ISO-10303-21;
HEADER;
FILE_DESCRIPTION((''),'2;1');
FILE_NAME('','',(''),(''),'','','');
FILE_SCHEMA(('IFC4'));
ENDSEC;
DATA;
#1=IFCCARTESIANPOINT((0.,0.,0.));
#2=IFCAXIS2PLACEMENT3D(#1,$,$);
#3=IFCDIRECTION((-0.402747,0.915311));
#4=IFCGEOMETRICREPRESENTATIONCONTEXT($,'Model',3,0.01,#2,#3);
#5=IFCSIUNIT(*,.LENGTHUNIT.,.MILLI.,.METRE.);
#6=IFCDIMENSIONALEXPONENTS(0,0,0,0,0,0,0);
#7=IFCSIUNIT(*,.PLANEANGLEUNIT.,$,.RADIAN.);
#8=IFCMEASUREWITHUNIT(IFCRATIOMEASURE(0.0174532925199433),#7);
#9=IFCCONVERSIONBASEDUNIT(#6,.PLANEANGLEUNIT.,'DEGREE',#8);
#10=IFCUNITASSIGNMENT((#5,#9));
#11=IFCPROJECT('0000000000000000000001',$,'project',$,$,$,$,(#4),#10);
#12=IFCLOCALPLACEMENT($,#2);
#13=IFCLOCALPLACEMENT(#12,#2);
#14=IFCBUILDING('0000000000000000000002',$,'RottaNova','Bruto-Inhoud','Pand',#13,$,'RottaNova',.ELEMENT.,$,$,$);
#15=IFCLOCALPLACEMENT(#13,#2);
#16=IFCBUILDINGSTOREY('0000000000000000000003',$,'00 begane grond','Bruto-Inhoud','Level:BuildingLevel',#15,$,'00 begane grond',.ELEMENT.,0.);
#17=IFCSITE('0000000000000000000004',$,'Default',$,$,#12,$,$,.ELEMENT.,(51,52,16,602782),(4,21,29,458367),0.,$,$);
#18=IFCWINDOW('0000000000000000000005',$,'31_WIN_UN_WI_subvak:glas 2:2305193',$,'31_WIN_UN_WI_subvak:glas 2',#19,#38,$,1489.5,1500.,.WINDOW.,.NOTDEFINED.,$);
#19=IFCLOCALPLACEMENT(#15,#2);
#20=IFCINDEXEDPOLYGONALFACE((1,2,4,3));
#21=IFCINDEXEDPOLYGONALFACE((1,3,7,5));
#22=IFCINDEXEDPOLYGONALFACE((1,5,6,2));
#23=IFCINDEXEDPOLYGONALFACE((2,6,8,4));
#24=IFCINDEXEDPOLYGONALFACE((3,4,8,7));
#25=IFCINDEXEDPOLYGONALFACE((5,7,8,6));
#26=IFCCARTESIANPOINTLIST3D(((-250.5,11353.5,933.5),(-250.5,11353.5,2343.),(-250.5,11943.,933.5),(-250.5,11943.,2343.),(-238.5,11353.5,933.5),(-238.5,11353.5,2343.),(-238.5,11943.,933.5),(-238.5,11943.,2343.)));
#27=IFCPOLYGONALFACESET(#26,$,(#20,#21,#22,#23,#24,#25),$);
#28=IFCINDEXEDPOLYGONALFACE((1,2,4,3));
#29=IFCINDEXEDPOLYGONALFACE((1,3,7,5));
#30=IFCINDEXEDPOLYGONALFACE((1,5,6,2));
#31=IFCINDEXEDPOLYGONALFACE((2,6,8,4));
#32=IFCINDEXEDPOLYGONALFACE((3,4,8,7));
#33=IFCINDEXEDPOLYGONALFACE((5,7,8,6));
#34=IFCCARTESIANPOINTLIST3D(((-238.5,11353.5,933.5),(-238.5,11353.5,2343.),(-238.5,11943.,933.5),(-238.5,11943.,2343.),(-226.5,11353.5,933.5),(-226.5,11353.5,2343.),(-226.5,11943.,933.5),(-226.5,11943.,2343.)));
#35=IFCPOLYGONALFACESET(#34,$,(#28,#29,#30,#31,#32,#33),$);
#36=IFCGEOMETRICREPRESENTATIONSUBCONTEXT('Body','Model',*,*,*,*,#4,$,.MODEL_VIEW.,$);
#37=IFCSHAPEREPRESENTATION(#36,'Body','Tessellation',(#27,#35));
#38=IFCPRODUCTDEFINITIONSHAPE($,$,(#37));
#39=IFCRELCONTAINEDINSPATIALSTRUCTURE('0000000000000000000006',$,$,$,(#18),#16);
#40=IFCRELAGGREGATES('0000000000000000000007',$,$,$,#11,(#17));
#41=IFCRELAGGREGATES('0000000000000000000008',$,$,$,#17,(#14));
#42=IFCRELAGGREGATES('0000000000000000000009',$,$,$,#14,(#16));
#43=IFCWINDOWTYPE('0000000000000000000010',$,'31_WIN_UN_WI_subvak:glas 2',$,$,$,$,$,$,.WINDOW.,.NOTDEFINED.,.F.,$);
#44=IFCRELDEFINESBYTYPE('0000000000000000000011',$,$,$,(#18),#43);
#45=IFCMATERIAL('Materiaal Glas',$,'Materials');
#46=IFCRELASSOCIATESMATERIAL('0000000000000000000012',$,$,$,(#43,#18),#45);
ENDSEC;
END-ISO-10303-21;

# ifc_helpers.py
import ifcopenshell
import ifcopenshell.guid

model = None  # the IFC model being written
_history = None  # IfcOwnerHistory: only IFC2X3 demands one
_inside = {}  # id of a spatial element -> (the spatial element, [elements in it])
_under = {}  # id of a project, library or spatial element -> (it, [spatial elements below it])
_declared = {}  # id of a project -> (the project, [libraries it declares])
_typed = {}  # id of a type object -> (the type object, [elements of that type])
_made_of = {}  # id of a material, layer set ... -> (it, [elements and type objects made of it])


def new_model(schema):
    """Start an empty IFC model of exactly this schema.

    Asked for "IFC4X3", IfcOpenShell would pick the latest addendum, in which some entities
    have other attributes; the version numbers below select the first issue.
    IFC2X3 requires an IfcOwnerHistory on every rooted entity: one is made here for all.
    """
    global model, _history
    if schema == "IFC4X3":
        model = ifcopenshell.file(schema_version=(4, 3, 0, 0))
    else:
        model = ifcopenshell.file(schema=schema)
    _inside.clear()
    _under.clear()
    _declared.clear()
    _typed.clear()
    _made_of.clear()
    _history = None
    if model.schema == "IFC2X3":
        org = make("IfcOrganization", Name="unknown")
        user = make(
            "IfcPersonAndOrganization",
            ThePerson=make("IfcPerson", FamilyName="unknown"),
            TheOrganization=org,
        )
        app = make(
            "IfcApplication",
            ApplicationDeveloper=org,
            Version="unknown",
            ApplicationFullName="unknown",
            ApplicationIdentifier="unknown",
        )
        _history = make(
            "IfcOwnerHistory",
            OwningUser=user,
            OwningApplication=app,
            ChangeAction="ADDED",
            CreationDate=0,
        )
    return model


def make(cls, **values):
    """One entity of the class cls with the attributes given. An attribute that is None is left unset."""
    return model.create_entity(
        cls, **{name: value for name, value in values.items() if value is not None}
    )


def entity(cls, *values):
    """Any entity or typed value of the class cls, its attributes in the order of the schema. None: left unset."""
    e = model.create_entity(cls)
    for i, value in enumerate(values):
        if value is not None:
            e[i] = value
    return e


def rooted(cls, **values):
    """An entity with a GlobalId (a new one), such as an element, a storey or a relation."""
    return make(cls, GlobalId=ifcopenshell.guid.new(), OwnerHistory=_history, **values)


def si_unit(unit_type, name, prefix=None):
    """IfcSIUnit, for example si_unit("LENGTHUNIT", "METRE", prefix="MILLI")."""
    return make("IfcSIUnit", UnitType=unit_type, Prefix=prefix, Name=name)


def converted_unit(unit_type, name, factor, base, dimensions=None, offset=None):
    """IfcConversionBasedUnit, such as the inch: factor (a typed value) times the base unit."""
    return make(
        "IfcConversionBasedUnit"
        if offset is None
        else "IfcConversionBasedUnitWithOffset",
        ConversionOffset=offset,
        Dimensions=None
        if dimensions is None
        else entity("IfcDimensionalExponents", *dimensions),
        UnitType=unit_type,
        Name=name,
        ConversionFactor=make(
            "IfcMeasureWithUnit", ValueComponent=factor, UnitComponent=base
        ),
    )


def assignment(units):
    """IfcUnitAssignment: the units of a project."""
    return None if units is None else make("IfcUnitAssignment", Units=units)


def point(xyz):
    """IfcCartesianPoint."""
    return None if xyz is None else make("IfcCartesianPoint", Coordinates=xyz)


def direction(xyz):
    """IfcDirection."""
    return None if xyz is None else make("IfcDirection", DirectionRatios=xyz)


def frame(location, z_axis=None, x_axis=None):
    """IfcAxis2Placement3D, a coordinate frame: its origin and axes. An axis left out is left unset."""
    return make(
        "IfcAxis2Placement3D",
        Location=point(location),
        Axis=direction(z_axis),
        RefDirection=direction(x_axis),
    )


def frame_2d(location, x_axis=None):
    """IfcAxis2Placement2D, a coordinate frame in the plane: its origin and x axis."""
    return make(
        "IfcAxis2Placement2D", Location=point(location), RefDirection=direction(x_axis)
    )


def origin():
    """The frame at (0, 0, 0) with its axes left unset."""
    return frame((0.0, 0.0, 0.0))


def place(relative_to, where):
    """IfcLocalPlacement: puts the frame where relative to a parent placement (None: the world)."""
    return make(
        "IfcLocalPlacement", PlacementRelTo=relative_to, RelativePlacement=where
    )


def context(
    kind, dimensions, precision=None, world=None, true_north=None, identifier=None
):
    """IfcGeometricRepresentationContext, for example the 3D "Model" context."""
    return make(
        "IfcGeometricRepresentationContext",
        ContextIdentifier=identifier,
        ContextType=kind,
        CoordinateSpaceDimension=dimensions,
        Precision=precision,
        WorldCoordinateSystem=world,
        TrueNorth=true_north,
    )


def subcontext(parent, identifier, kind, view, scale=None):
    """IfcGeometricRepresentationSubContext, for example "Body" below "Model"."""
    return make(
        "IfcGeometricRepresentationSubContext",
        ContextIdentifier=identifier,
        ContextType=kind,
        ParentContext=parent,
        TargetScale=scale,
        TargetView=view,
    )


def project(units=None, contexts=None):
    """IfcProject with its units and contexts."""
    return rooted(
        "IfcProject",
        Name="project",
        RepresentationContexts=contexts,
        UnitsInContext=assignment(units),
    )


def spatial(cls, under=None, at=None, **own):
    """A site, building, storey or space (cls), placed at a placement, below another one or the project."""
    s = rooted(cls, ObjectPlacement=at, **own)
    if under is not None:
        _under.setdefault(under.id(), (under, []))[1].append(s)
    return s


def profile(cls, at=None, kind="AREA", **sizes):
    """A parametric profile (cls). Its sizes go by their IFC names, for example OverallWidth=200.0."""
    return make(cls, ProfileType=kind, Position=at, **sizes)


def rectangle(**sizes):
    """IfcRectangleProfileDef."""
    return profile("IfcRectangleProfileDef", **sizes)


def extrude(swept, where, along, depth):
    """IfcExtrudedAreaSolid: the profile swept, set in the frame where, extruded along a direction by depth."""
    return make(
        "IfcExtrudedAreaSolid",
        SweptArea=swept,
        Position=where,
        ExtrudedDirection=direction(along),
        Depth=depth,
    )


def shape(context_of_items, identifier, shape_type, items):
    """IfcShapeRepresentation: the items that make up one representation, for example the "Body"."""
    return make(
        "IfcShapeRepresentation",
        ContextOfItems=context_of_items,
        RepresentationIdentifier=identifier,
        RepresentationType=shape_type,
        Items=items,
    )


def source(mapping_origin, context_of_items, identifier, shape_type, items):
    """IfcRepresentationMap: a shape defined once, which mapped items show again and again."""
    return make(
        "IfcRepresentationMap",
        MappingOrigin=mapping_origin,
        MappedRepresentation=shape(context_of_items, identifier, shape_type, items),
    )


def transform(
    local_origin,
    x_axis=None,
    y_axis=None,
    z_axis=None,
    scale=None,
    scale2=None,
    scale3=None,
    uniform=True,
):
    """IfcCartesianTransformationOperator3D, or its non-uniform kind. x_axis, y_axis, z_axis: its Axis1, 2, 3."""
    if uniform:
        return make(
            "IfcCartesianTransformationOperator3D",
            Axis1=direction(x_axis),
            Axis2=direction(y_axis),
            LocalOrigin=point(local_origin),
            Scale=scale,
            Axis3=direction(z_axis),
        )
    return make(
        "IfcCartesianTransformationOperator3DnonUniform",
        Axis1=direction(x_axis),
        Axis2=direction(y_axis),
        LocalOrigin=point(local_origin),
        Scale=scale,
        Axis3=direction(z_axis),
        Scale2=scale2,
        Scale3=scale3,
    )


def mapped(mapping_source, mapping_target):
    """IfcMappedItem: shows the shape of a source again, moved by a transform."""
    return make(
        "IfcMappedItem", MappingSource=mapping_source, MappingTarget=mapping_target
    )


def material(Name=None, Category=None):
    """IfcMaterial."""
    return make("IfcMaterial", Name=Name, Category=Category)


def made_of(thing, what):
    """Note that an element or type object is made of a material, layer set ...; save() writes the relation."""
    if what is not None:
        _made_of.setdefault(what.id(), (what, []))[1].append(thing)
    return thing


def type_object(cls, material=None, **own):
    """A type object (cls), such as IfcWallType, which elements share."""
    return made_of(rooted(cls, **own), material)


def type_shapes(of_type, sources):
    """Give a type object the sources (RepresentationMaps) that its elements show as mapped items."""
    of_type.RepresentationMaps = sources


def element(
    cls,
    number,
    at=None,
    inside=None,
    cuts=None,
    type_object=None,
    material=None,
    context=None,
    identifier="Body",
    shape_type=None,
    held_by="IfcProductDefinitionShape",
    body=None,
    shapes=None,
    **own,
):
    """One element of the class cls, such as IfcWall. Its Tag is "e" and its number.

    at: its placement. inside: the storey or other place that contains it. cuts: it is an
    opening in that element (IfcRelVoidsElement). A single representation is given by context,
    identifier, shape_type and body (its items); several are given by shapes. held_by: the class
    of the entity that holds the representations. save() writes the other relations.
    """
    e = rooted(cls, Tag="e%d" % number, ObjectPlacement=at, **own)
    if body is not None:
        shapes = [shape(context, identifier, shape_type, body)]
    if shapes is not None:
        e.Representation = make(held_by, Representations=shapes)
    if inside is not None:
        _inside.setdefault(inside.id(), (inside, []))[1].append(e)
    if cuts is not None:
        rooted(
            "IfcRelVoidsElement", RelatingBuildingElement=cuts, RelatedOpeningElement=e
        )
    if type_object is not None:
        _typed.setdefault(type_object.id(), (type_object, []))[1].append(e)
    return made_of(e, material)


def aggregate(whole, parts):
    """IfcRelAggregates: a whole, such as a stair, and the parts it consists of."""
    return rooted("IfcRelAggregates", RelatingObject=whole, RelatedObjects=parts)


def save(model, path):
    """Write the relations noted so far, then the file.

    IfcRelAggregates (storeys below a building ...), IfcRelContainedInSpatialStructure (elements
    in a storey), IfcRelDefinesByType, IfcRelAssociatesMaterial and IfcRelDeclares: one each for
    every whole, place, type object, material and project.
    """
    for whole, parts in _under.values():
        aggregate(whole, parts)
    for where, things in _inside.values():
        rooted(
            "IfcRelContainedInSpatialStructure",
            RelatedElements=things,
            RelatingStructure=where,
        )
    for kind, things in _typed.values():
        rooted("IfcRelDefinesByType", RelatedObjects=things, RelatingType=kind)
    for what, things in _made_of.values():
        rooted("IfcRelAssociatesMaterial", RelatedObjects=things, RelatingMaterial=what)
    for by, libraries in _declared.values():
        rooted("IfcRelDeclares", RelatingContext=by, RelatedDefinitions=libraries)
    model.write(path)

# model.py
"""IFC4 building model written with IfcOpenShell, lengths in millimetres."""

from ifc_helpers import new_model, entity, si_unit, converted_unit, direction, frame, frame_2d, origin, place, context, subcontext, project, spatial, rectangle, extrude, source, transform, mapped, material, type_object, type_shapes, element, save


model = new_model("IFC4")

# Units and contexts
model_context = context("Model", 3, precision=0.01, world=origin(), true_north=direction((-0.402747, 0.915311)))
body_context = subcontext(model_context, "Body", "Model", "MODEL_VIEW")
ifc_project = project(units=[si_unit("LENGTHUNIT", "METRE", prefix="MILLI"), converted_unit("PLANEANGLEUNIT", "DEGREE", entity("IfcRatioMeasure", 0.0174532925199433), si_unit("PLANEANGLEUNIT", "RADIAN"), dimensions=[0, 0, 0, 0, 0, 0, 0])], contexts=[model_context])

# Site, building, storey
site_placement = place(None, origin())
site = spatial("IfcSite", under=ifc_project, at=site_placement, Name="Default", CompositionType="ELEMENT", RefLatitude=(51, 52, 16, 602782), RefLongitude=(4, 21, 29, 458367), RefElevation=0.0)
building_placement = place(site_placement, origin())
building = spatial("IfcBuilding", under=site, at=building_placement, Name="RottaNova", Description="Bruto-Inhoud", ObjectType="Pand", LongName="RottaNova", CompositionType="ELEMENT")
storey_placement = place(building_placement, origin())
storey = spatial("IfcBuildingStorey", under=building, at=storey_placement, Name="00 begane grond", Description="Bruto-Inhoud", ObjectType="Level:BuildingLevel", LongName="00 begane grond", CompositionType="ELEMENT", Elevation=0.0)

# Shared definitions
ifc_material_1 = material(Name="Materiaal Glas", Category="Materials")

# Window
window_type_1 = type_object("IfcWindowType", Name="31_WIN_UN_WI_subvak:glas 2", ParameterTakesPrecedence=False, PartitioningType="NOTDEFINED", PredefinedType="WINDOW", material=ifc_material_1)
shared_shape_1 = source(origin(), body_context, "Body", "SweptSolid", [
    extrude(rectangle(XDim=12.0, YDim=589.5, at=frame_2d((0.0, 0.0), x_axis=(1.0, 0.0))), frame((0.0, 6.0, 0.0), z_axis=(0.0, 0.0, 1.0), x_axis=(0.0, -1.0, 0.0)), (0.0, 0.0, 1.0), 1409.5),
    extrude(rectangle(XDim=12.0, YDim=589.5, at=frame_2d((0.0, 0.0), x_axis=(1.0, 0.0))), frame((0.0, -6.0, 0.0), z_axis=(0.0, 0.0, 1.0), x_axis=(0.0, -1.0, 0.0)), (0.0, 0.0, 1.0), 1409.5),
])
type_shapes(window_type_1, [shared_shape_1])
window_1_placement = place(storey_placement, frame((-238.5, 11648.2, 933.5), z_axis=(0.0, 0.0, 1.0), x_axis=(0.0, 1.0, 0.0)))
element("IfcWindow", 1, at=window_1_placement, inside=storey, type_object=window_type_1, material=ifc_material_1, Name="31_WIN_UN_WI_subvak:glas 2:2305193", ObjectType="31_WIN_UN_WI_subvak:glas 2", OverallHeight=1489.5, OverallWidth=1500.0, PartitioningType="NOTDEFINED", PredefinedType="WINDOW", context=body_context, shape_type="MappedRepresentation", body=[
    mapped(shared_shape_1, transform((0.0, 0.0, 0.0), scale=1.0)),
])

save(model, "model.ifc")
